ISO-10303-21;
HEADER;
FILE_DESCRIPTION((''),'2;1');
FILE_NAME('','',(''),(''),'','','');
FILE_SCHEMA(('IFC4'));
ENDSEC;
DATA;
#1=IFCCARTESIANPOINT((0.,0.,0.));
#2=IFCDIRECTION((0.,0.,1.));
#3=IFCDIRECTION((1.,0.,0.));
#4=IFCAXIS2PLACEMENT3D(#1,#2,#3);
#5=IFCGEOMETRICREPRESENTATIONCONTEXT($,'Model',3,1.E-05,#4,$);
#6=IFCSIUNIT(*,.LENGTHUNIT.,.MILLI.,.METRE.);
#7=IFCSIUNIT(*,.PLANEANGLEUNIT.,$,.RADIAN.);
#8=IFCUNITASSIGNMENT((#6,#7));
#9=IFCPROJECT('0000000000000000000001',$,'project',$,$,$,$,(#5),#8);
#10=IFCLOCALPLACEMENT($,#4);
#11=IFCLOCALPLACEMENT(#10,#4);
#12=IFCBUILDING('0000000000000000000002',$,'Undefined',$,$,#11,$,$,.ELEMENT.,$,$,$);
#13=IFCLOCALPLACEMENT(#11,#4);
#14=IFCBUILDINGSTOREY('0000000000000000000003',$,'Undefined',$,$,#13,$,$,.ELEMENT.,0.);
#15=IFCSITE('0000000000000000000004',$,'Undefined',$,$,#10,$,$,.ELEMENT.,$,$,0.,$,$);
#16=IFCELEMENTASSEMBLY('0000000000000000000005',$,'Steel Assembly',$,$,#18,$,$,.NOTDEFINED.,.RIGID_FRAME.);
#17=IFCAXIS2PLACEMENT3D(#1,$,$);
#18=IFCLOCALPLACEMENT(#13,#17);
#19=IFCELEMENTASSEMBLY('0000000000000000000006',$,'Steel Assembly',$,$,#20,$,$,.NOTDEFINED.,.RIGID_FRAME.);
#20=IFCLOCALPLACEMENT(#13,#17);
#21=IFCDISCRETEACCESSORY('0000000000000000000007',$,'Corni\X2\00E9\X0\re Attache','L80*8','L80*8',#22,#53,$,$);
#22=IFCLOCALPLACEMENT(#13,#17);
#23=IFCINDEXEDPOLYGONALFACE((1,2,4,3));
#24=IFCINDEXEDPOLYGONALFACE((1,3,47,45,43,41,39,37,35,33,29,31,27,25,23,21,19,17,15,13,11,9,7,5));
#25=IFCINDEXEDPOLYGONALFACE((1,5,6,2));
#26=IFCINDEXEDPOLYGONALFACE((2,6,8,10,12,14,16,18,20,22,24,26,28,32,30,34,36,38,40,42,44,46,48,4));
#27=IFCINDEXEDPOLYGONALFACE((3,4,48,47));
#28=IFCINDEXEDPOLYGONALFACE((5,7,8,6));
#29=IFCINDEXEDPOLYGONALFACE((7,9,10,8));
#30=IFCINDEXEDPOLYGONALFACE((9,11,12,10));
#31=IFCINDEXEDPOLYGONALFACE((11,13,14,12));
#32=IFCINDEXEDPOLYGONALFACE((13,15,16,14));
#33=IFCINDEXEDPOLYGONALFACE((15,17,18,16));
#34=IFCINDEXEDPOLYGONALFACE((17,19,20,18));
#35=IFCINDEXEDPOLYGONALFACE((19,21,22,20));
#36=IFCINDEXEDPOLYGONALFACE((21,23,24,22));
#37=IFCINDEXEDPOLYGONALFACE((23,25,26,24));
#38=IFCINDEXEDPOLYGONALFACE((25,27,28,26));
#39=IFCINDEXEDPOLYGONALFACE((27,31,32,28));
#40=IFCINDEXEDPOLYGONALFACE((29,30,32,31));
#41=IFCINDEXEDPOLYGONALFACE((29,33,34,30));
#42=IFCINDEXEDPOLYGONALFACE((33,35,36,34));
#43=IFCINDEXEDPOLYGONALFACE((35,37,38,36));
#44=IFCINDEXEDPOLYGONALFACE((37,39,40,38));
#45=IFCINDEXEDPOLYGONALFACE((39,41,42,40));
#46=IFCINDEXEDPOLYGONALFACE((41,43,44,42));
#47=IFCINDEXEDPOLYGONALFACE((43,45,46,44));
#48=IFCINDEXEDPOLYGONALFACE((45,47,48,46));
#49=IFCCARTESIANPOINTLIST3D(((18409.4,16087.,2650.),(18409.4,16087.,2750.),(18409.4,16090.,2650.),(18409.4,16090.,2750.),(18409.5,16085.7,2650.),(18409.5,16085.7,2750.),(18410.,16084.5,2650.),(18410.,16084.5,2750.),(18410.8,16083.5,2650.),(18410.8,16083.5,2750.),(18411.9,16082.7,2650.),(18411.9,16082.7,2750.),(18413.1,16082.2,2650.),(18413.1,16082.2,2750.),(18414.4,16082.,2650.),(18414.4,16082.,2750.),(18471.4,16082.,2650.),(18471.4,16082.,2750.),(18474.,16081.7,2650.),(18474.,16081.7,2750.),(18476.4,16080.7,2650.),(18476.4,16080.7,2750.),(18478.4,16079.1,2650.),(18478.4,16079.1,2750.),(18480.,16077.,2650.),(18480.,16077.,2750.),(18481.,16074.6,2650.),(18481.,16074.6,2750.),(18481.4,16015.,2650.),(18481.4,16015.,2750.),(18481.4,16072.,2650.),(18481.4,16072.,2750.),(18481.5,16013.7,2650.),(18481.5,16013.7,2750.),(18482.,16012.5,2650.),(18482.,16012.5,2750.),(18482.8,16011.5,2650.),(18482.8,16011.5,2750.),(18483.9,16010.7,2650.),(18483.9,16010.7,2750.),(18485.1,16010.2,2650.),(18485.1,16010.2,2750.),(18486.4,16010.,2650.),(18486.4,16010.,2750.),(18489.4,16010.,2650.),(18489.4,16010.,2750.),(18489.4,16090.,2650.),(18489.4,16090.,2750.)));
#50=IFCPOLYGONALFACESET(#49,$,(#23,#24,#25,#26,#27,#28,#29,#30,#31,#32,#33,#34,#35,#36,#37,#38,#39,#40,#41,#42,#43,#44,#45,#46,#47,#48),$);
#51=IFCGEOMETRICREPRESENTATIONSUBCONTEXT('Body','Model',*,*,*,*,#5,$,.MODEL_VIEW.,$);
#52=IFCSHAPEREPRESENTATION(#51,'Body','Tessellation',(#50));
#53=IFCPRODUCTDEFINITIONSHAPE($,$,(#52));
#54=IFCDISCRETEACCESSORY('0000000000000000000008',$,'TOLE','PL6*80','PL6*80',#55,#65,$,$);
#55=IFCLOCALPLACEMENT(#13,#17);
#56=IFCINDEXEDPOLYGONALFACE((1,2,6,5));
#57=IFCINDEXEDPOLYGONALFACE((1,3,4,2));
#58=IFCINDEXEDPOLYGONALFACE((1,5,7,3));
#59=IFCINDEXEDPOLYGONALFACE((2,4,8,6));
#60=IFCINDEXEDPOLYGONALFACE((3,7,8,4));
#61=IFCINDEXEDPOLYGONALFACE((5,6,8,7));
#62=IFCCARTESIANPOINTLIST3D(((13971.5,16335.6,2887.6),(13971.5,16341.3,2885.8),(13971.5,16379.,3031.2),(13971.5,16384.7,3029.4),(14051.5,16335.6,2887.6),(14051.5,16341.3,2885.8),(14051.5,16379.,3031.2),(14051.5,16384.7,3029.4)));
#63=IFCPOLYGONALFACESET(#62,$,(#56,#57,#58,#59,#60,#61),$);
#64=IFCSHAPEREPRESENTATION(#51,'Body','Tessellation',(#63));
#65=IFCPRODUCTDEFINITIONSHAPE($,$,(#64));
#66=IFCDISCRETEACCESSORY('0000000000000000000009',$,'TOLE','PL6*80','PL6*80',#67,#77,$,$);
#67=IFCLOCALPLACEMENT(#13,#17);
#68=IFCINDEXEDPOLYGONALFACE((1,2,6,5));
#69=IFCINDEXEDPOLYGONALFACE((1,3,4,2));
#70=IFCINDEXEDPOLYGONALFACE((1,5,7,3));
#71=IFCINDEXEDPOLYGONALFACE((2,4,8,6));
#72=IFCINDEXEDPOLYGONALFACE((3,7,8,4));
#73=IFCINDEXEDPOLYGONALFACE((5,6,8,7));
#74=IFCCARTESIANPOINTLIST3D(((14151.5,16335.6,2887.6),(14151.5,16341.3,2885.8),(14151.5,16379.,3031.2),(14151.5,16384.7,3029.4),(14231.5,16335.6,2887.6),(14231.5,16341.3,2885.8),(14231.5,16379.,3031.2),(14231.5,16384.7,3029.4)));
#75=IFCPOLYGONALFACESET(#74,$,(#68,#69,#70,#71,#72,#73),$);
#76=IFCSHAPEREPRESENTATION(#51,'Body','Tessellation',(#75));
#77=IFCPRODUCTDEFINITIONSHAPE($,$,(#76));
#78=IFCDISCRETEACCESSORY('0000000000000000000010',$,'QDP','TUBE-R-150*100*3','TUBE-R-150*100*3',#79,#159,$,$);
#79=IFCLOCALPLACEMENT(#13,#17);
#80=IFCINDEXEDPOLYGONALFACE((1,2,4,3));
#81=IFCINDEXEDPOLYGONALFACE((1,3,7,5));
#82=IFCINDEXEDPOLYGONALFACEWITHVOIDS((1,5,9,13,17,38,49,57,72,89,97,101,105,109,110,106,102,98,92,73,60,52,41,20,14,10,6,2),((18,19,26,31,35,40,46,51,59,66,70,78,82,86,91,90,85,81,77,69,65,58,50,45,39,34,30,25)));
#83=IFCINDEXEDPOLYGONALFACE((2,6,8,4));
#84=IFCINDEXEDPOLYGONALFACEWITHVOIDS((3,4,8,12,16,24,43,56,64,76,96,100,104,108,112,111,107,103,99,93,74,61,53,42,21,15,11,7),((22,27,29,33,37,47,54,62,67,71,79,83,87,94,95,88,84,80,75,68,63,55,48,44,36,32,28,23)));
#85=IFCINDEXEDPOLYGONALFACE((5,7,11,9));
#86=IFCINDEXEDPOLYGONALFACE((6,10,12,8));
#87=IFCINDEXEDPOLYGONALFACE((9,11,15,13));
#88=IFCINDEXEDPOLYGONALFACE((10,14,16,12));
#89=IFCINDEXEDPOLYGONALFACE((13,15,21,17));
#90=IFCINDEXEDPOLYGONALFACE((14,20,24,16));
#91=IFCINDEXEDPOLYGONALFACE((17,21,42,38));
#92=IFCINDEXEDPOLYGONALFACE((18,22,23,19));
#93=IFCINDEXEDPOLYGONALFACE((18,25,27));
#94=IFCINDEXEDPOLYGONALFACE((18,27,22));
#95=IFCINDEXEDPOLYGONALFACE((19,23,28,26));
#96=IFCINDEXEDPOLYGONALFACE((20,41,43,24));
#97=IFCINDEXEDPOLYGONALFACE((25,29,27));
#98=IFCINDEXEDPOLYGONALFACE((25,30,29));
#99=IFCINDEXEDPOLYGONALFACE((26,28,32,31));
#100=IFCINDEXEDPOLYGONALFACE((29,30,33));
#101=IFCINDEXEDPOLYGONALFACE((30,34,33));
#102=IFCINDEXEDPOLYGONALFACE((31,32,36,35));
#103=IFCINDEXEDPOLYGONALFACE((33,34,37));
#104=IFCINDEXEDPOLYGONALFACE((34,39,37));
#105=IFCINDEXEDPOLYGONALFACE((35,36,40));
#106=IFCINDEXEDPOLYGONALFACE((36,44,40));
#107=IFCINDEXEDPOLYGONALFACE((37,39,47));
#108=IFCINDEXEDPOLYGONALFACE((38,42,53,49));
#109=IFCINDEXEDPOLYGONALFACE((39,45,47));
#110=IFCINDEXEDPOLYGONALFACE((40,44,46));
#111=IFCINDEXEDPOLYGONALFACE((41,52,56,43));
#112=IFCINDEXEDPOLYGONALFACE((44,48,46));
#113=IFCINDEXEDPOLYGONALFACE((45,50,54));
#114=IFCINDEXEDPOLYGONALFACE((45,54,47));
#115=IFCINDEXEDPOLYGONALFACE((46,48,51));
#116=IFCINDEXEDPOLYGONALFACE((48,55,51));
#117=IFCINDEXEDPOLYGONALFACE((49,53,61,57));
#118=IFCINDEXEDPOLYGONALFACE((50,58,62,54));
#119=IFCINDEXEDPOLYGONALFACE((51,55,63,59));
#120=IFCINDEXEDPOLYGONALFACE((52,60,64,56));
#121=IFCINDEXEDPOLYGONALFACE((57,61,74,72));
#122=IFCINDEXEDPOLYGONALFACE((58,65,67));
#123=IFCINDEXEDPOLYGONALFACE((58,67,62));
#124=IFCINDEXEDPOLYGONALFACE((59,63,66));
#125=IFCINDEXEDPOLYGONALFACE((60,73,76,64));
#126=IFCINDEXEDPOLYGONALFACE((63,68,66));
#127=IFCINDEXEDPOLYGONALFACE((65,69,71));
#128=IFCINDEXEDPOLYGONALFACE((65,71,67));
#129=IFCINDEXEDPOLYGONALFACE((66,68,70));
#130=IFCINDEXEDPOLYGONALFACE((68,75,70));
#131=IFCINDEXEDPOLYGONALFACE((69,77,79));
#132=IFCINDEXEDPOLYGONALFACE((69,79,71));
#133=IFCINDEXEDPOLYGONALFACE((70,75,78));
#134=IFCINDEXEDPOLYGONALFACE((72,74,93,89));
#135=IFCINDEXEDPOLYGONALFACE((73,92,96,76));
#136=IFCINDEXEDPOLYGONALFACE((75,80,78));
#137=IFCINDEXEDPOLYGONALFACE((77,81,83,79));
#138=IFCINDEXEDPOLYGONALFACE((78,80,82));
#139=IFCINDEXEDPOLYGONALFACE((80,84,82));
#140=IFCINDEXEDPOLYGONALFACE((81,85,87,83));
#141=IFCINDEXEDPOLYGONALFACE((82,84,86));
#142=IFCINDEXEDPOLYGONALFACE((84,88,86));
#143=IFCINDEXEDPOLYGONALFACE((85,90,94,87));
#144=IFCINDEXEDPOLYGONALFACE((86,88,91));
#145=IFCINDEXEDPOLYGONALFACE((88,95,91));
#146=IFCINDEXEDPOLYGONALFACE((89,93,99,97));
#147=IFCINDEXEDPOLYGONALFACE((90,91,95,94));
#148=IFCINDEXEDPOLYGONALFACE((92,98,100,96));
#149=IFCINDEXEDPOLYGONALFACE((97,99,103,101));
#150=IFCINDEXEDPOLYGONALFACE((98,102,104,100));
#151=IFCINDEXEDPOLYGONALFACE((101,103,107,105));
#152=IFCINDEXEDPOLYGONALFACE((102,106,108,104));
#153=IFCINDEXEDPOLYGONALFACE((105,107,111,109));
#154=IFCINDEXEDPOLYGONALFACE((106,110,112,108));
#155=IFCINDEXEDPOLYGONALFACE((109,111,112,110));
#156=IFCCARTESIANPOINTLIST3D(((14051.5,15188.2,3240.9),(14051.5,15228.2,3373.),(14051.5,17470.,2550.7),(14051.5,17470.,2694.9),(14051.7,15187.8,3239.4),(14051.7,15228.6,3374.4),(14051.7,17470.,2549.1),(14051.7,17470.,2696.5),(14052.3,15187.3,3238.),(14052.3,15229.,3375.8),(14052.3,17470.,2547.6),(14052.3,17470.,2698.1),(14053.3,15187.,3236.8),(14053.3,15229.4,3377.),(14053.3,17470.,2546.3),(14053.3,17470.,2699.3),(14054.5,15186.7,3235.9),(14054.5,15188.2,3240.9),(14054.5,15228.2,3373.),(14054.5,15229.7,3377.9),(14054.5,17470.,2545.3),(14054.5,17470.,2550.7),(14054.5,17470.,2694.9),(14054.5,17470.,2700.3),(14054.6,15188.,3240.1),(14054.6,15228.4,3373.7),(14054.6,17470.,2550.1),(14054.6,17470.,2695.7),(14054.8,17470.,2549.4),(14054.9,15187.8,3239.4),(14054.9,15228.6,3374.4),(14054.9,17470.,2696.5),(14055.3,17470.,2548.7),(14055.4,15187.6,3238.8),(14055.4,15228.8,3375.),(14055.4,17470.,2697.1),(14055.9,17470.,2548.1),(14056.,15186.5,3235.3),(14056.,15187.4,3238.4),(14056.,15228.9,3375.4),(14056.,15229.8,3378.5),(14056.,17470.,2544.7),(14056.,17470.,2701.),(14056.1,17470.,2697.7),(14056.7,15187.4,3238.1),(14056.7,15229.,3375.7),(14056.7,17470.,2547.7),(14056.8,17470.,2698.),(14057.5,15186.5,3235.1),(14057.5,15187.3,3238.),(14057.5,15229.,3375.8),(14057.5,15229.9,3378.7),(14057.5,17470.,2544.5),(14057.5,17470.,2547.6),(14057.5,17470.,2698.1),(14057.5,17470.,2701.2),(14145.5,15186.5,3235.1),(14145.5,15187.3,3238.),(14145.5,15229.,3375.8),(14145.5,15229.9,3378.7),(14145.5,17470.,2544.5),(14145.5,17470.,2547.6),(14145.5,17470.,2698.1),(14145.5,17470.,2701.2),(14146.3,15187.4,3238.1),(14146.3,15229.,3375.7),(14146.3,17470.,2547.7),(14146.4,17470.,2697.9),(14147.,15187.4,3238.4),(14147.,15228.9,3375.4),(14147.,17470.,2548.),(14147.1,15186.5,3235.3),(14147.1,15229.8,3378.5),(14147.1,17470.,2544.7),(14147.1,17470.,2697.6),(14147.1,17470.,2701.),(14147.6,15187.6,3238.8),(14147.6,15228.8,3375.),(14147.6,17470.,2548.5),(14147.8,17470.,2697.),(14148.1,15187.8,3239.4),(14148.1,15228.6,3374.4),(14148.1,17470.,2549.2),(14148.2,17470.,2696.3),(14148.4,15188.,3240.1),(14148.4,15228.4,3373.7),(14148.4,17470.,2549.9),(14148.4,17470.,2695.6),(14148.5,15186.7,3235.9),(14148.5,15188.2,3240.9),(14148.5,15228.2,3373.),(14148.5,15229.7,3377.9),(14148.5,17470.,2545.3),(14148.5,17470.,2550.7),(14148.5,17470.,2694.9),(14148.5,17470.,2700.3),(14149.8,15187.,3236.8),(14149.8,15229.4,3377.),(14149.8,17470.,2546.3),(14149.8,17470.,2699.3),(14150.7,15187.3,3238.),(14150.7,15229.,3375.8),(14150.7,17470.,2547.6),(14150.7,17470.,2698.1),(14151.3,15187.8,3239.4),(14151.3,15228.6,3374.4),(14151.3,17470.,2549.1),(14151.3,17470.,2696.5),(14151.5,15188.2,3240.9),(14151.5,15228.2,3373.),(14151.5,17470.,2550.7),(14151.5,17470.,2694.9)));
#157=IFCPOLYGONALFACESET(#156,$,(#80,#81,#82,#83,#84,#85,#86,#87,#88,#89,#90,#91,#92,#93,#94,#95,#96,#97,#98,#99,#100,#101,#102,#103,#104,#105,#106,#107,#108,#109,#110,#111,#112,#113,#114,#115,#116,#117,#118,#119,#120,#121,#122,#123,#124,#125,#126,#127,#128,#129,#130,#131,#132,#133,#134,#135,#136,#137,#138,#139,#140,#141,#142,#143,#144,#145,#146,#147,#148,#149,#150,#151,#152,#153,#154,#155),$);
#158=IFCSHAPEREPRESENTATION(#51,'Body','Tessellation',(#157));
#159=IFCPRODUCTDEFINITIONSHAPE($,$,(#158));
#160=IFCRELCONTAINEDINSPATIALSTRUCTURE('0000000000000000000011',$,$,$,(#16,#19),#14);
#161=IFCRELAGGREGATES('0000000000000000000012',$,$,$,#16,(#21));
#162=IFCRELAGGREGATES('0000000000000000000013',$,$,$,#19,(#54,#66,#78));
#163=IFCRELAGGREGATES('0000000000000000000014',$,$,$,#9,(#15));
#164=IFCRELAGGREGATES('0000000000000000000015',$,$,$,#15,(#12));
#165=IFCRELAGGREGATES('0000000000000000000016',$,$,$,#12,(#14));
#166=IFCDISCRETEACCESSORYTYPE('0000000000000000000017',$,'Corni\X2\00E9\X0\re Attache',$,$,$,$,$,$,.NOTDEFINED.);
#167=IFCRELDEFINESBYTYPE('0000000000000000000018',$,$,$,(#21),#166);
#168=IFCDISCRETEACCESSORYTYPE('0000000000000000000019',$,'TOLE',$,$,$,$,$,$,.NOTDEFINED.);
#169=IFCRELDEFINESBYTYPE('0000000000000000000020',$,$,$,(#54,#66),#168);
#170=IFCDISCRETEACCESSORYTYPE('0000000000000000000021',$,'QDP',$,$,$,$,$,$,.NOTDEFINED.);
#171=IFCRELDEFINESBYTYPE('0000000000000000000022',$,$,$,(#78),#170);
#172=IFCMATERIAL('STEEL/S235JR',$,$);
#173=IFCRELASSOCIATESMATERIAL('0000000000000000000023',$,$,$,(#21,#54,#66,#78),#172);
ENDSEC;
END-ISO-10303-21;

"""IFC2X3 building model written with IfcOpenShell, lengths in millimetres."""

from ifc_helpers import new_model, si_unit, frame, origin_with_axes, origin_2d_with_axis, place, context, subcontext, project, spatial, rectangle, hollow_rectangle, l_section, extrude, clip, halfspace, material, type_object, element, aggregate, save


model = new_model("IFC2X3")

# Units and contexts
model_context = context("Model", 3, precision=1e-05, world=origin_with_axes())
body_context = subcontext(model_context, "Body", "Model", "MODEL_VIEW")
ifc_project = project(units=[si_unit("LENGTHUNIT", "METRE", prefix="MILLI"), si_unit("PLANEANGLEUNIT", "RADIAN")], contexts=[model_context])

# Site, building, storey
site_placement = place(None, origin_with_axes())
site = spatial("IfcSite", under=ifc_project, at=site_placement, Name="Undefined", CompositionType="ELEMENT", RefElevation=0.0)
building_placement = place(site_placement, origin_with_axes())
building = spatial("IfcBuilding", under=site, at=building_placement, Name="Undefined", CompositionType="ELEMENT")
storey_placement = place(building_placement, origin_with_axes())
storey = spatial("IfcBuildingStorey", under=building, at=storey_placement, Name="Undefined", CompositionType="ELEMENT", Elevation=0.0)

# Element assembly
assembly_1_placement = place(storey_placement, origin_with_axes())
assembly_1 = element("IfcElementAssembly", 1, at=assembly_1_placement, inside=storey, Name="Steel Assembly", AssemblyPlace="NOTDEFINED", PredefinedType="RIGID_FRAME")
ifc_material_1 = material(Name="STEEL/S235JR")

# Element assembly
assembly_2_placement = place(storey_placement, origin_with_axes())
assembly_2 = element("IfcElementAssembly", 2, at=assembly_2_placement, inside=storey, Name="Steel Assembly", AssemblyPlace="NOTDEFINED", PredefinedType="RIGID_FRAME")

# Discrete accessories
discrete_accessory_type_1 = type_object("IfcDiscreteAccessoryType", Name="Corniére Attache")
discrete_accessory_1_placement = place(assembly_1_placement, frame((18449.4, 16050.0, 2750.0), z_axis=(0.0, -1.0, 0.0), x_axis=(0.0, 0.0, -1.0)))
discrete_accessory_1 = element("IfcDiscreteAccessory", 3, at=discrete_accessory_1_placement, type_object=discrete_accessory_type_1, material=ifc_material_1, Name="Corniére Attache", Description="L80*8", ObjectType="L80*8", context=body_context, shape_type="SweptSolid", body=[
    extrude(l_section(Depth=80.0, Width=80.0, Thickness=8.0, FilletRadius=10.0, EdgeRadius=5.0, at=origin_2d_with_axis()), frame((100.0, 0.0, 0.0), z_axis=(-1.0, 0.0, 0.0), x_axis=(0.0, -1.0, 0.0)), (0.0, 0.0, 1.0), 100.0),
])
aggregate(assembly_1, [discrete_accessory_1])
discrete_accessory_type_2 = type_object("IfcDiscreteAccessoryType", Name="TOLE")
discrete_accessory_2_placement = place(assembly_2_placement, frame((14011.5, 16381.9, 3030.3), z_axis=(1.0, 0.0, 0.0), x_axis=(0.0, -0.289497, -0.957179)))
discrete_accessory_2 = element("IfcDiscreteAccessory", 4, at=discrete_accessory_2_placement, type_object=discrete_accessory_type_2, material=ifc_material_1, Name="TOLE", Description="PL6*80", ObjectType="PL6*80", context=body_context, shape_type="SweptSolid", body=[
    extrude(rectangle(XDim=6.0, YDim=80.0, at=origin_2d_with_axis()), frame((150.0, 0.0, 0.0), z_axis=(-1.0, 0.0, 0.0), x_axis=(0.0, -1.0, 0.0)), (0.0, 0.0, 1.0), 150.0),
])
discrete_accessory_3_placement = place(assembly_2_placement, frame((14191.5, 16381.9, 3030.3), z_axis=(-1.0, 0.0, 0.0), x_axis=(0.0, -0.289497, -0.957179)))
discrete_accessory_3 = element("IfcDiscreteAccessory", 5, at=discrete_accessory_3_placement, type_object=discrete_accessory_type_2, material=ifc_material_1, Name="TOLE", Description="PL6*80", ObjectType="PL6*80", context=body_context, shape_type="SweptSolid", body=[
    extrude(rectangle(XDim=6.0, YDim=80.0, at=origin_2d_with_axis()), frame((150.0, 0.0, 0.0), z_axis=(-1.0, 0.0, 0.0), x_axis=(0.0, -1.0, 0.0)), (0.0, 0.0, 1.0), 150.0),
])
discrete_accessory_type_3 = type_object("IfcDiscreteAccessoryType", Name="QDP")
discrete_accessory_4_placement = place(assembly_2_placement, frame((14101.5, 15208.1, 3306.9), z_axis=(0.0, 0.289497, 0.957179), x_axis=(0.0, 0.957179, -0.289497)))
discrete_accessory_4 = element("IfcDiscreteAccessory", 6, at=discrete_accessory_4_placement, type_object=discrete_accessory_type_3, material=ifc_material_1, Name="QDP", Description="TUBE-R-150*100*3", ObjectType="TUBE-R-150*100*3", context=body_context, shape_type="Clipping", body=[
    clip(extrude(hollow_rectangle(XDim=100.0, YDim=150.0, WallThickness=3.0, InnerFilletRadius=3.0, OuterFilletRadius=6.0, at=origin_2d_with_axis()), frame((2427.9, 0.0, 0.0), z_axis=(-1.0, 0.0, 0.0), x_axis=(0.0, -1.0, 0.0)), (0.0, 0.0, 1.0), 2427.9), halfspace(frame((2361.5, 0.0, 5.2), z_axis=(0.957179, 0.0, 0.289497), x_axis=(0.0, -1.0, 0.0)), False)),
])
aggregate(assembly_2, [discrete_accessory_2, discrete_accessory_3, discrete_accessory_4])

save(model, "model.ifc")
